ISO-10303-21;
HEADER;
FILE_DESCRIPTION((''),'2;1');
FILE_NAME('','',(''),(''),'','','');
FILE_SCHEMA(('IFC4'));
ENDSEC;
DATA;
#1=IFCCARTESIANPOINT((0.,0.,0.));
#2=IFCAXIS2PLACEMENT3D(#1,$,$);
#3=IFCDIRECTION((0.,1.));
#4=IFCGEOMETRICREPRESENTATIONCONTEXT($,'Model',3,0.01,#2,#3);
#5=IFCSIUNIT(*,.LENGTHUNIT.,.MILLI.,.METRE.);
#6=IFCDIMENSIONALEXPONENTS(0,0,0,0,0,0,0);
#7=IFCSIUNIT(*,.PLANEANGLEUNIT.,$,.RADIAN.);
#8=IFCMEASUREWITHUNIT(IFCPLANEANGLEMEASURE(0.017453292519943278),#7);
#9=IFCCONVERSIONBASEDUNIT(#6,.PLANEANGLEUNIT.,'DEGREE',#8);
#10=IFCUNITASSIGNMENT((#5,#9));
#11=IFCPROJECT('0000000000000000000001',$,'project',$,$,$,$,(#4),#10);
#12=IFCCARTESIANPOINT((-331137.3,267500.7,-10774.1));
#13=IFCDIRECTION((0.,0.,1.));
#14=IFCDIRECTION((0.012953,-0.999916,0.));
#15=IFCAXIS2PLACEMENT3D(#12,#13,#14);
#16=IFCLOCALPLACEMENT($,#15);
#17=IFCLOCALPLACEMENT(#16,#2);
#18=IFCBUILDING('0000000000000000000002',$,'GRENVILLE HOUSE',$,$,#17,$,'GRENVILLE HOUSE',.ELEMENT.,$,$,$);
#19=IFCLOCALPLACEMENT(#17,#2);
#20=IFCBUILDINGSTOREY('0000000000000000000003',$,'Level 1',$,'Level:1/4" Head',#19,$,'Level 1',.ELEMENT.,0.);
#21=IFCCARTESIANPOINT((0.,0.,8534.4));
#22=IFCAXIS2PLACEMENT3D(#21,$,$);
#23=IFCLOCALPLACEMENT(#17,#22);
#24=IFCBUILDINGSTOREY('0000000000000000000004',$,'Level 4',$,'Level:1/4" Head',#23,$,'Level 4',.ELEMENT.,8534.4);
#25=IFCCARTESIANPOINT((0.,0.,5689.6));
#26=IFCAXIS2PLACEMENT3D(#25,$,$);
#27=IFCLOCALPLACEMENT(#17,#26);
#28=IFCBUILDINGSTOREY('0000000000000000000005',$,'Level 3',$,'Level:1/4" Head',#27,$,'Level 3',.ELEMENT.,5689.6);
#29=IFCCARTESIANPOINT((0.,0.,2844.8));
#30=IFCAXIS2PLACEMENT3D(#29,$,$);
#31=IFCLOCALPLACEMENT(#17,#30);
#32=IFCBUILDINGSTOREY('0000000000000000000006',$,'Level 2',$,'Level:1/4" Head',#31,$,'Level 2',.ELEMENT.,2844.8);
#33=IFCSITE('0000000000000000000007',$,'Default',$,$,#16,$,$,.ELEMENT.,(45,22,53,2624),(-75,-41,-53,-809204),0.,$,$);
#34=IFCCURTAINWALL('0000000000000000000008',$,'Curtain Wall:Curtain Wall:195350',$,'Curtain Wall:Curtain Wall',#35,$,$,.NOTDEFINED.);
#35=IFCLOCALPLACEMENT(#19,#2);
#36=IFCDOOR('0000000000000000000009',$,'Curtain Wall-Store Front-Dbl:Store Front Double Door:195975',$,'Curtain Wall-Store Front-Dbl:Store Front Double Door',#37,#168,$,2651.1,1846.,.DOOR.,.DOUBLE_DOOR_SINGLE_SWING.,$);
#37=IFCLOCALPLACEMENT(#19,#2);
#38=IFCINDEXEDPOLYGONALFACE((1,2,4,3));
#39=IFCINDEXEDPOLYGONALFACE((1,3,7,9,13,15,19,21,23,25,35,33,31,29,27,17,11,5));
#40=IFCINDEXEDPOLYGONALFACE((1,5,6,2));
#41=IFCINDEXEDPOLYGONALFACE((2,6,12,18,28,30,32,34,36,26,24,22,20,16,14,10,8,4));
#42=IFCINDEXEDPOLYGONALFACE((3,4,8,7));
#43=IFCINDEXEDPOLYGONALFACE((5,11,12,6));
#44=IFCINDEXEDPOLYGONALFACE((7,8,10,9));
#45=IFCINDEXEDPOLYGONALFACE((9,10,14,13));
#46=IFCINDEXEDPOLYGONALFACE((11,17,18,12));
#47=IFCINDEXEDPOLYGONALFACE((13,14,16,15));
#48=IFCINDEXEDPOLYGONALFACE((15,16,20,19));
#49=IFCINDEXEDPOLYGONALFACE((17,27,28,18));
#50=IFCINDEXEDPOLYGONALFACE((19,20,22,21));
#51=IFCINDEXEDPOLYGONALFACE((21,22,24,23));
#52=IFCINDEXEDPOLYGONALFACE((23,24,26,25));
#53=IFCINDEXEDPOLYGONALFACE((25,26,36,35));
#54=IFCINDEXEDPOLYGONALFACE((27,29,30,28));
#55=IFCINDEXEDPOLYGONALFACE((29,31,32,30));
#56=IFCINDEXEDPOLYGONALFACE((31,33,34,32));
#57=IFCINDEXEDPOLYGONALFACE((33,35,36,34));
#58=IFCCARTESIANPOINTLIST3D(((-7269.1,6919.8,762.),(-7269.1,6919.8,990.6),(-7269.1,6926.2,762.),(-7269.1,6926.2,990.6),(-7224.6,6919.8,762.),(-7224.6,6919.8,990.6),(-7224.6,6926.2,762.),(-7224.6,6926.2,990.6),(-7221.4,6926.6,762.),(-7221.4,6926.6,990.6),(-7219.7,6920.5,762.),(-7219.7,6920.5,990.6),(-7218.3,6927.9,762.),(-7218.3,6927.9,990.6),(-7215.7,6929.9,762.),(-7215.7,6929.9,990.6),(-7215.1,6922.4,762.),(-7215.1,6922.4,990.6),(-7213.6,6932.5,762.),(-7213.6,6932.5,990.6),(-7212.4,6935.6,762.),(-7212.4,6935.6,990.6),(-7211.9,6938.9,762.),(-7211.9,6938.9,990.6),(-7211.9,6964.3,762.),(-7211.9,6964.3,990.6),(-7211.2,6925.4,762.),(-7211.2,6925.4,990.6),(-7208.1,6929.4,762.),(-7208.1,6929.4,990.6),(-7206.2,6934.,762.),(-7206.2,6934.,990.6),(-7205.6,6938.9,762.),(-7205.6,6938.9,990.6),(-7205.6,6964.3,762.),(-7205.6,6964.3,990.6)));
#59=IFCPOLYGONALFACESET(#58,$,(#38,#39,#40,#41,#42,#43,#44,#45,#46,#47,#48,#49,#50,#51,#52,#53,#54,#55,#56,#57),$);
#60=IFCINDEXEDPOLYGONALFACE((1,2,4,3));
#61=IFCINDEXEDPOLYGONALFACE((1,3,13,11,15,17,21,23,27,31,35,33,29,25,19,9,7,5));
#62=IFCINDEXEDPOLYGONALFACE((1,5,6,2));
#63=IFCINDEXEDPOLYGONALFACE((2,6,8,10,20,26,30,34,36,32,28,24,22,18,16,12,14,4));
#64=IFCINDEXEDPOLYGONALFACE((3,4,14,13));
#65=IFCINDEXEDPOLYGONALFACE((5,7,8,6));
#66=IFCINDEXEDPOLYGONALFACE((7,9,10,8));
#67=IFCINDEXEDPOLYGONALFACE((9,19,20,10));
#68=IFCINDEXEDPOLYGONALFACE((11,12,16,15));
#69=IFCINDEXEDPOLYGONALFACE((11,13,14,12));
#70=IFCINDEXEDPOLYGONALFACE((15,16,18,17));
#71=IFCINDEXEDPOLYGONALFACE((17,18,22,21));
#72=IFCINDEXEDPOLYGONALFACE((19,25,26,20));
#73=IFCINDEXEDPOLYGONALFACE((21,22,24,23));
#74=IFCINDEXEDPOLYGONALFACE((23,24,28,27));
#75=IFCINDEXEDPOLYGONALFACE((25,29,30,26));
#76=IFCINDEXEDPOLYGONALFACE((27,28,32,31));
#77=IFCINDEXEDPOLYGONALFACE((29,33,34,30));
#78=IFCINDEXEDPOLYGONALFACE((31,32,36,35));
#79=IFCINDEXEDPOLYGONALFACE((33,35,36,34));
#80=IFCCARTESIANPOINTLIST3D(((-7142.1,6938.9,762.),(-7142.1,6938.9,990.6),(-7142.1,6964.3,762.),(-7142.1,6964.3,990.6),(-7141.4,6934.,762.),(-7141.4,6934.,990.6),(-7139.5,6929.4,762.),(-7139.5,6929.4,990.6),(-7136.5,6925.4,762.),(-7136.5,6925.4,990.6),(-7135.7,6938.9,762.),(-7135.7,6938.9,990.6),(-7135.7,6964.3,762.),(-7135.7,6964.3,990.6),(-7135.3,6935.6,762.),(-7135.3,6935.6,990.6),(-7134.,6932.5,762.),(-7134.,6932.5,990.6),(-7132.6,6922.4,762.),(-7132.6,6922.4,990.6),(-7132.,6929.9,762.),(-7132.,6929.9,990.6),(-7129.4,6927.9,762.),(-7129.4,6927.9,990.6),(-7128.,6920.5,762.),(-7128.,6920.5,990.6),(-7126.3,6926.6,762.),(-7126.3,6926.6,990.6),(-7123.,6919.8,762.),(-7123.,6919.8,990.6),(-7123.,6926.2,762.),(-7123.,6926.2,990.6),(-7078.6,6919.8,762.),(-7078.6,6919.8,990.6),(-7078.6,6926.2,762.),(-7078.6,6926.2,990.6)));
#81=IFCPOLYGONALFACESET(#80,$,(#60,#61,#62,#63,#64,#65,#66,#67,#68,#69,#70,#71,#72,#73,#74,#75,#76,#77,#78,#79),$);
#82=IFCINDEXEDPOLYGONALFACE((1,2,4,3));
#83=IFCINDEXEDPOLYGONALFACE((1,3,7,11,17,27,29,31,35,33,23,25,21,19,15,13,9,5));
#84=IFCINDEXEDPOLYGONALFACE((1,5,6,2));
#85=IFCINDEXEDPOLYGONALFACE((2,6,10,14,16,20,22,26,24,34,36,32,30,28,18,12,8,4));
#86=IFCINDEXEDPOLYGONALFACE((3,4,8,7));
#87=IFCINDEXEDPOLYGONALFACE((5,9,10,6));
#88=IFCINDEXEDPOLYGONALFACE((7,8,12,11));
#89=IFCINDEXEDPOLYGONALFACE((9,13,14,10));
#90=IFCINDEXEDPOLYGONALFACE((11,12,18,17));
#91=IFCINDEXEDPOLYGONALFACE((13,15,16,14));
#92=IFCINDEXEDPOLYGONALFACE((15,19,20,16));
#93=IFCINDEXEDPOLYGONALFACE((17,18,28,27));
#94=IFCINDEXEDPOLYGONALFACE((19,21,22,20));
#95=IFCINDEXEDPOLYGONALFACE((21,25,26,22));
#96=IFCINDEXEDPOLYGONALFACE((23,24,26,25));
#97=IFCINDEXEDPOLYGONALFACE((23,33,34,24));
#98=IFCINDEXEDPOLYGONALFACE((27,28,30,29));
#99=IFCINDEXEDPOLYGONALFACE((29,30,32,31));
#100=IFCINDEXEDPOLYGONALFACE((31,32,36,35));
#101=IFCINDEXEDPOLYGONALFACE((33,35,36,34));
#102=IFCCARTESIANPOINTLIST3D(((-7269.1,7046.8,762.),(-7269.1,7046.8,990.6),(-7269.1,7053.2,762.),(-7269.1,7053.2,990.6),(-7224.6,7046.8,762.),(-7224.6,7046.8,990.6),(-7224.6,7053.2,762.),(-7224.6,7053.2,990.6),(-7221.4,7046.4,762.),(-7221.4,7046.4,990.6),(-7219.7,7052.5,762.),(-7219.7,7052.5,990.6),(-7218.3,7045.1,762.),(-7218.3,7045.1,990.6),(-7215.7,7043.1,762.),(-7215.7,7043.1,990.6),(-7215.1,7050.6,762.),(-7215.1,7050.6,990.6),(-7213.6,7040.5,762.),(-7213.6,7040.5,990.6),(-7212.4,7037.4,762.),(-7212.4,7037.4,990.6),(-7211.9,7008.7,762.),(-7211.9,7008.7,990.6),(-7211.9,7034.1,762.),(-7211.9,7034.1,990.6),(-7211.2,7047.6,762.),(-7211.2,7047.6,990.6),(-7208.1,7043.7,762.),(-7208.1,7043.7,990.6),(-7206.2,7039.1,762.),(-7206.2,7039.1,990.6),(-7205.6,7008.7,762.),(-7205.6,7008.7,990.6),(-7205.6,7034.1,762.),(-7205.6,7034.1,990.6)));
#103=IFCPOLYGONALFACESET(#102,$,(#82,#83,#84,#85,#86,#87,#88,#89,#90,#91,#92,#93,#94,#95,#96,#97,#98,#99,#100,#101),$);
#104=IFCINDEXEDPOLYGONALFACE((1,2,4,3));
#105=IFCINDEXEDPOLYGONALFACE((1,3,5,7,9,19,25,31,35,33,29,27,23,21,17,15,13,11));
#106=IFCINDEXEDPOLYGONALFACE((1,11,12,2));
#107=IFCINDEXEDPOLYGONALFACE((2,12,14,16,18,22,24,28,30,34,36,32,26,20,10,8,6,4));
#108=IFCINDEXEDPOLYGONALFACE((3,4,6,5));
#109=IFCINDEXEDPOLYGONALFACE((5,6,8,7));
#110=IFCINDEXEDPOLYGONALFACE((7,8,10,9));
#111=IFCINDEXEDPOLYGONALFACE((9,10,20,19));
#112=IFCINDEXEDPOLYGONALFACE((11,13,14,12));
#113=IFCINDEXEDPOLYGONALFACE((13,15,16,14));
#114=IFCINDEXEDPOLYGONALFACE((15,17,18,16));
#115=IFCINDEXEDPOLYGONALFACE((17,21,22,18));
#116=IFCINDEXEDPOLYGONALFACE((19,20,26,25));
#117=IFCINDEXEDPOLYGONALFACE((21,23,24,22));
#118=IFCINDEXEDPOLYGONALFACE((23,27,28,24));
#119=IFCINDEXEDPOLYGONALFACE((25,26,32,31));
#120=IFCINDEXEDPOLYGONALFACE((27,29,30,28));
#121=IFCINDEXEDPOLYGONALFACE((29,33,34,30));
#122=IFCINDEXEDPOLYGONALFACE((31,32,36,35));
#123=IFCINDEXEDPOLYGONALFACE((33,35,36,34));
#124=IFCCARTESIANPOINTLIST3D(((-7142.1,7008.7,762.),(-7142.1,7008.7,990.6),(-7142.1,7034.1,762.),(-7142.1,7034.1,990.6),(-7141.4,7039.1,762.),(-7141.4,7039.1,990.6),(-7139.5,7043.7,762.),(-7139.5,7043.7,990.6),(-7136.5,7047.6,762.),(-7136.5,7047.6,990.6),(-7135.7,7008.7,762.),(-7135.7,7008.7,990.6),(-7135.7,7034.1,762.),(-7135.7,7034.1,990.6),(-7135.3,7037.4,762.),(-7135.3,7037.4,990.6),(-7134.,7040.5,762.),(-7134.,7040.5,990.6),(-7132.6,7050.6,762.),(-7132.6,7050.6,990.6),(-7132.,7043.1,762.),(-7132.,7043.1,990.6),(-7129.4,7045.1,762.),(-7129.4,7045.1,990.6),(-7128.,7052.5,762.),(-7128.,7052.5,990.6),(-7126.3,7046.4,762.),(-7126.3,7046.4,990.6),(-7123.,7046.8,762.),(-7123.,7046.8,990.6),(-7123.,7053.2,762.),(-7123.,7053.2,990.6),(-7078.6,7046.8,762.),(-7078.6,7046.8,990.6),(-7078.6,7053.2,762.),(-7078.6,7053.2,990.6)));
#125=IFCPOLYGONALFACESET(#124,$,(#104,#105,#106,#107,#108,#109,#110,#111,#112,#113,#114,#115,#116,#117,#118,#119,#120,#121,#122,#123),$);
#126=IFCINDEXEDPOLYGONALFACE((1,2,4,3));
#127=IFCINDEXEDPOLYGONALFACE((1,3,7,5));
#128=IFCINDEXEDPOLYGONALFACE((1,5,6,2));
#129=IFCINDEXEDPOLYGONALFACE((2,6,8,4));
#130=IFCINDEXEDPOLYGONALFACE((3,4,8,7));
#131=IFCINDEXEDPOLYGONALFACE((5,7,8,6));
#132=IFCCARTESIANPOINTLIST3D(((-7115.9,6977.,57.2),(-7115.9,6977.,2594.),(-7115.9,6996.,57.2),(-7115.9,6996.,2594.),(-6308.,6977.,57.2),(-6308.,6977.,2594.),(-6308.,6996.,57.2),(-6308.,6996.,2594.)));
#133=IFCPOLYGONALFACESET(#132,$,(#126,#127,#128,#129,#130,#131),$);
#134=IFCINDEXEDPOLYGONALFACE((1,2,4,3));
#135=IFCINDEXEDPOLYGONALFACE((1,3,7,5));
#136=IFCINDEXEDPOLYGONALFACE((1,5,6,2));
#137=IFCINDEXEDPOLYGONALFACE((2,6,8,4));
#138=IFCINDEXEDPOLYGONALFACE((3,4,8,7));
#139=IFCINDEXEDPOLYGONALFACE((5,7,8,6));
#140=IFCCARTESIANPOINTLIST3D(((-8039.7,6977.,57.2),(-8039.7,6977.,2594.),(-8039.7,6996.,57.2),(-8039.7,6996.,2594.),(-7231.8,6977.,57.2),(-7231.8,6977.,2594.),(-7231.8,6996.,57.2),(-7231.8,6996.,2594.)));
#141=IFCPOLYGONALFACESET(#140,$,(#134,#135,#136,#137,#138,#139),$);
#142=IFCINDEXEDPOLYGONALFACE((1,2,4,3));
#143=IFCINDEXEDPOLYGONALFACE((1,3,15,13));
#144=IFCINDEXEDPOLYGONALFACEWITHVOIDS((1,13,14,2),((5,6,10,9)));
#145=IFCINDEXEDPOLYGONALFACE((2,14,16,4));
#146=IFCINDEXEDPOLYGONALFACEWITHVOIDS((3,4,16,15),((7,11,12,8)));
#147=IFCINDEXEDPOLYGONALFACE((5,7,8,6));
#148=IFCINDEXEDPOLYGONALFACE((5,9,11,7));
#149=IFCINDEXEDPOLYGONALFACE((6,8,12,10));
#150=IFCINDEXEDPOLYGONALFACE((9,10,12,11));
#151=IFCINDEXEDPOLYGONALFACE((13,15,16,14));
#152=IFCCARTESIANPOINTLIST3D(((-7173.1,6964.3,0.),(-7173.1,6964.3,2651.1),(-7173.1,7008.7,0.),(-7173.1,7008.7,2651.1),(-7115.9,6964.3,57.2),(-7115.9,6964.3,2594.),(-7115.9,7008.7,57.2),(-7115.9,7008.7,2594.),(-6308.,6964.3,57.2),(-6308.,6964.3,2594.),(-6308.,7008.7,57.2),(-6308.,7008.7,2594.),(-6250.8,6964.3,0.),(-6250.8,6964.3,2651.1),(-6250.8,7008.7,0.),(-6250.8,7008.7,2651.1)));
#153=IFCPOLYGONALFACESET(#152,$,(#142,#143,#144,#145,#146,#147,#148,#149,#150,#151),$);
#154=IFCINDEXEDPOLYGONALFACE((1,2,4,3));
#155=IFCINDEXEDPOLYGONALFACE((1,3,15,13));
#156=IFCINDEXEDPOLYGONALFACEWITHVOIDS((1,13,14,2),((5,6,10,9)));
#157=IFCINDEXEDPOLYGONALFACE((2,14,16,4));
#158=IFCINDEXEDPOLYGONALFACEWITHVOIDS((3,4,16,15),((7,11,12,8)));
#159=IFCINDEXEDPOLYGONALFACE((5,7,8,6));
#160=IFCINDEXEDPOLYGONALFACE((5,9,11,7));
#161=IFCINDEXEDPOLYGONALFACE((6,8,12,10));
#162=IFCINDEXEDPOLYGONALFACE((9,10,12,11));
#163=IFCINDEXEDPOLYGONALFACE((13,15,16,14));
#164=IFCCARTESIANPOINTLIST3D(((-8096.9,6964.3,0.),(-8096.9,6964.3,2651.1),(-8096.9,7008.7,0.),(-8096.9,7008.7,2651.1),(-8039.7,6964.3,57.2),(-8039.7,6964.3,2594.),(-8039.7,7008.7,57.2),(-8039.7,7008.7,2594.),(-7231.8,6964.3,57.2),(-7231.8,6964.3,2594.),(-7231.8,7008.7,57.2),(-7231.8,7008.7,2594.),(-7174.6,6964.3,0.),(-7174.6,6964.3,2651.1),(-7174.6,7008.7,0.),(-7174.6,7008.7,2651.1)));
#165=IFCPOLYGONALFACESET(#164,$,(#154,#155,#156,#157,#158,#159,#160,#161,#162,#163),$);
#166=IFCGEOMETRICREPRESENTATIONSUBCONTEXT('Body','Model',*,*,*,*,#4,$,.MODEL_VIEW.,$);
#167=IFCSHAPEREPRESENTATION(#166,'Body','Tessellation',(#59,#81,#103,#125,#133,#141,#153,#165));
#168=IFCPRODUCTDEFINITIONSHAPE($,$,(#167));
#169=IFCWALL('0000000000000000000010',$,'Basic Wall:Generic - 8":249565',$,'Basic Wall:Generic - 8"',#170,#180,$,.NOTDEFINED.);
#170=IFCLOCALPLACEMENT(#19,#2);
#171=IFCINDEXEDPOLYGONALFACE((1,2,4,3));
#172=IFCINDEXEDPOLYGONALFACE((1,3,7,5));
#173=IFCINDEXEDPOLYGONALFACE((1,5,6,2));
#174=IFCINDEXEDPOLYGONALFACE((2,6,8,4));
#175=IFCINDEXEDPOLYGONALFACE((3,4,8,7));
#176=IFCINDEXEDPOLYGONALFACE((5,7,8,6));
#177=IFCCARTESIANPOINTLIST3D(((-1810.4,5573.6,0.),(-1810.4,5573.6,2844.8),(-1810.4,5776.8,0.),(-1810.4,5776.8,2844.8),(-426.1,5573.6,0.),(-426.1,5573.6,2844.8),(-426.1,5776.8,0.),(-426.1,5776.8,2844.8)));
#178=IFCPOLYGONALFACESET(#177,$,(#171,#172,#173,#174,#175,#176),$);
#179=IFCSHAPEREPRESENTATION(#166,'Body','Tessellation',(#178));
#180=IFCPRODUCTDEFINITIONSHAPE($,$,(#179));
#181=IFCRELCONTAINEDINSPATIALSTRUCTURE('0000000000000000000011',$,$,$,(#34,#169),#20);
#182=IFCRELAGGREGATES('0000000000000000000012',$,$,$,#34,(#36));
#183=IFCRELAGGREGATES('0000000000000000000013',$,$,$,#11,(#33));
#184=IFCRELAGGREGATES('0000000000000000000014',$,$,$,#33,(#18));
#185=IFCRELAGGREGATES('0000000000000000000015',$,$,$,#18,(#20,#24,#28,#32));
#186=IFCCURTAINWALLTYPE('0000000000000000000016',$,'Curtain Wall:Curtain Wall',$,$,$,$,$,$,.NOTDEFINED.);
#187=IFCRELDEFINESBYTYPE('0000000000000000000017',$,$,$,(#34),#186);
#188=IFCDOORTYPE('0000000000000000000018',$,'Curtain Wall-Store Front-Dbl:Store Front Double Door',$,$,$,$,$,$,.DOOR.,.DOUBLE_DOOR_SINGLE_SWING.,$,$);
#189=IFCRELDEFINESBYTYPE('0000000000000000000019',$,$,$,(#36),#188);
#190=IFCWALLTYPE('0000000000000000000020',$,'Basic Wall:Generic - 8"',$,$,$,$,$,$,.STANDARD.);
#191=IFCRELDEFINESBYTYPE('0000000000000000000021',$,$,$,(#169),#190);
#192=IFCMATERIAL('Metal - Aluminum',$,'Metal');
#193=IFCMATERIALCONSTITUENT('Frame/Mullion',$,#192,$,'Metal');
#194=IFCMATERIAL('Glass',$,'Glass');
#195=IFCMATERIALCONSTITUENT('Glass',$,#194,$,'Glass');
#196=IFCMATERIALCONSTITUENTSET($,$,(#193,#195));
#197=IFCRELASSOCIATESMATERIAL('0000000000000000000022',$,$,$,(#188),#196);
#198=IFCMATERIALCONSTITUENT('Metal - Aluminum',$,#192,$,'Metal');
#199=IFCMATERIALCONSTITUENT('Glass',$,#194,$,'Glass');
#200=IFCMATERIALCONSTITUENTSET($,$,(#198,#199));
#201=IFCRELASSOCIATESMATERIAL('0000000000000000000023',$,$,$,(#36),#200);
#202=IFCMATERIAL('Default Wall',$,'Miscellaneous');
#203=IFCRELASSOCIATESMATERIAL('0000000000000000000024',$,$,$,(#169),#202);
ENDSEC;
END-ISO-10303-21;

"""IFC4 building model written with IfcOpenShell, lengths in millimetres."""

from ifc_helpers import new_model, entity, si_unit, converted_unit, direction, frame, origin, place, context, subcontext, project, spatial, line, arc, indexed_curve, outline, extrude, source, transform, mapped, material, constituent, constituent_set, type_object, type_shapes, element, aggregate, save


model = new_model("IFC4")

# Units and contexts
model_context = context("Model", 3, precision=0.01, world=origin(), true_north=direction((0.0, 1.0)))
body_context = subcontext(model_context, "Body", "Model", "MODEL_VIEW")
ifc_project = project(units=[si_unit("LENGTHUNIT", "METRE", prefix="MILLI"), converted_unit("PLANEANGLEUNIT", "DEGREE", entity("IfcPlaneAngleMeasure", 0.017453292519943278), si_unit("PLANEANGLEUNIT", "RADIAN"), dimensions=[0, 0, 0, 0, 0, 0, 0])], contexts=[model_context])

# Site, building, storey
site_placement = place(None, frame((-331137.3, 267500.7, -10774.1), z_axis=(0.0, 0.0, 1.0), x_axis=(0.012953, -0.999916, 0.0)))
site = spatial("IfcSite", under=ifc_project, at=site_placement, Name="Default", CompositionType="ELEMENT", RefLatitude=(45, 22, 53, 2624), RefLongitude=(-75, -41, -53, -809204), RefElevation=0.0)
building_placement = place(site_placement, origin())
building = spatial("IfcBuilding", under=site, at=building_placement, Name="GRENVILLE HOUSE", LongName="GRENVILLE HOUSE", CompositionType="ELEMENT")
storey_1_placement = place(building_placement, origin())
storey_1 = spatial("IfcBuildingStorey", under=building, at=storey_1_placement, Name="Level 1", ObjectType="Level:1/4\" Head", LongName="Level 1", CompositionType="ELEMENT", Elevation=0.0)

# Curtain wall
curtain_wall_type = type_object("IfcCurtainWallType", Name="Curtain Wall:Curtain Wall", PredefinedType="NOTDEFINED")
curtain_wall_placement = place(storey_1_placement, origin())
curtain_wall = element("IfcCurtainWall", 1, at=curtain_wall_placement, inside=storey_1, type_object=curtain_wall_type, Name="Curtain Wall:Curtain Wall:195350", ObjectType="Curtain Wall:Curtain Wall", PredefinedType="NOTDEFINED")
ifc_material_1 = material(Name="Glass", Category="Glass")

# Shared definitions
storey_2_placement = place(building_placement, frame((0.0, 0.0, 8534.4)))
storey_2 = spatial("IfcBuildingStorey", under=building, at=storey_2_placement, Name="Level 4", ObjectType="Level:1/4\" Head", LongName="Level 4", CompositionType="ELEMENT", Elevation=8534.4)

# Shared definitions
storey_3_placement = place(building_placement, frame((0.0, 0.0, 5689.6)))
storey_3 = spatial("IfcBuildingStorey", under=building, at=storey_3_placement, Name="Level 3", ObjectType="Level:1/4\" Head", LongName="Level 3", CompositionType="ELEMENT", Elevation=5689.6)

# Shared definitions
storey_4_placement = place(building_placement, frame((0.0, 0.0, 2844.8)))
storey_4 = spatial("IfcBuildingStorey", under=building, at=storey_4_placement, Name="Level 2", ObjectType="Level:1/4\" Head", LongName="Level 2", CompositionType="ELEMENT", Elevation=2844.8)

# Door
ifc_material_2 = material(Name="Metal - Aluminum", Category="Metal")
ifc_constituent_1 = constituent(ifc_material_2, Name="Metal - Aluminum", Category="Metal")
ifc_constituent_2 = constituent(ifc_material_1, Name="Glass", Category="Glass")
ifc_constituent_set_1 = constituent_set(constituents=[ifc_constituent_1, ifc_constituent_2])
ifc_constituent_3 = constituent(ifc_material_2, Name="Frame/Mullion", Category="Metal")
ifc_constituent_4 = constituent(ifc_material_1, Name="Glass", Category="Glass")
ifc_constituent_set_2 = constituent_set(constituents=[ifc_constituent_3, ifc_constituent_4])
door_type_1 = type_object("IfcDoorType", Name="Curtain Wall-Store Front-Dbl:Store Front Double Door", OperationType="DOUBLE_DOOR_SINGLE_SWING", PredefinedType="DOOR", material=ifc_constituent_set_2)
shared_shape_1 = source(origin(), body_context, "Body", "SweptSolid", [
    extrude(outline(indexed_curve([(1.6, -22.2), (27.0, -22.2), (27.0, -15.9), (1.6, -15.9), (-7.4, -12.2), (-11.1, -3.2), (-11.1, 41.3), (-17.5, 41.3), (-17.5, -3.2), (-11.9, -16.6)], segments=[line(1, 2, 3, 4), arc(4, 5, 6), line(6, 7, 8, 9), arc(9, 10, 1)], self_intersect=False)), frame((-54.0, -14.3, 762.0), z_axis=(0.0, 0.0, 1.0), x_axis=(0.0, 1.0, 0.0)), (0.0, 0.0, 1.0), 228.6),
    extrude(outline(indexed_curve([(22.2, -1.6), (16.6, 11.9), (3.2, 17.5), (-41.3, 17.5), (-41.3, 11.1), (3.2, 11.1), (12.2, 7.4), (15.9, -1.6), (15.9, -27.0), (22.2, -27.0)], segments=[arc(1, 2, 3), line(3, 4, 5, 6), arc(6, 7, 8), line(8, 9, 10, 1)], self_intersect=False)), frame((54.0, -14.3, 762.0), z_axis=(0.0, 0.0, 1.0), x_axis=(-1.0, 0.0, 0.0)), (0.0, 0.0, 1.0), 228.6),
    extrude(outline(indexed_curve([(-22.2, 1.6), (-16.6, -11.9), (-3.2, -17.5), (41.3, -17.5), (41.3, -11.1), (-3.2, -11.1), (-12.2, -7.4), (-15.9, 1.6), (-15.9, 27.0), (-22.2, 27.0)], segments=[arc(1, 2, 3), line(3, 4, 5, 6), arc(6, 7, 8), line(8, 9, 10, 1)], self_intersect=False)), frame((-54.0, 84.1, 762.0), z_axis=(0.0, 0.0, 1.0), x_axis=(-1.0, 0.0, 0.0)), (0.0, 0.0, 1.0), 228.6),
    extrude(outline(indexed_curve([(1.6, -22.2), (27.0, -22.2), (27.0, -15.9), (1.6, -15.9), (-7.4, -12.2), (-11.1, -3.2), (-11.1, 41.3), (-17.5, 41.3), (-17.5, -3.2), (-11.9, -16.6)], segments=[line(1, 2, 3, 4), arc(4, 5, 6), line(6, 7, 8, 9), arc(9, 10, 1)], self_intersect=False)), frame((54.0, 84.1, 762.0), z_axis=(0.0, 0.0, 1.0), x_axis=(0.0, -1.0, 0.0)), (0.0, 0.0, 1.0), 228.6),
    extrude(outline(indexed_curve([(-404.0, -9.5), (404.0, -9.5), (404.0, 9.5), (-404.0, 9.5), (-404.0, -9.5)], self_intersect=False)), frame((461.9, 34.9, 57.2)), (0.0, 0.0, 1.0), 2536.8),
    extrude(outline(indexed_curve([(-404.0, -9.5), (404.0, -9.5), (404.0, 9.5), (-404.0, 9.5), (-404.0, -9.5)], self_intersect=False)), frame((-461.9, 34.9, 57.2)), (0.0, 0.0, 1.0), 2536.8),
    extrude(outline(indexed_curve([(-1325.6, -461.1), (1325.6, -461.1), (1325.6, 461.1), (-1325.6, 461.1), (-1325.6, -461.1)], self_intersect=False), holes=[indexed_curve([(-1268.4, 404.0), (1268.4, 404.0), (1268.4, -404.0), (-1268.4, -404.0), (-1268.4, 404.0)], self_intersect=False)]), frame((461.9, 57.2, 1325.6), z_axis=(0.0, -1.0, 0.0), x_axis=(0.0, 0.0, -1.0)), (0.0, 0.0, 1.0), 44.4),
    extrude(outline(indexed_curve([(-461.1, -1325.6), (461.1, -1325.6), (461.1, 1325.6), (-461.1, 1325.6), (-461.1, -1325.6)], self_intersect=False), holes=[indexed_curve([(-404.0, -1268.4), (-404.0, 1268.4), (404.0, 1268.4), (404.0, -1268.4), (-404.0, -1268.4)], self_intersect=False)]), frame((-461.9, 57.2, 1325.6), z_axis=(0.0, -1.0, 0.0), x_axis=(-1.0, 0.0, 0.0)), (0.0, 0.0, 1.0), 44.4),
])
type_shapes(door_type_1, [shared_shape_1])
door_1_placement = place(curtain_wall_placement, frame((-7173.8, 6951.6, 0.0)))
door_1 = element("IfcDoor", 2, at=door_1_placement, type_object=door_type_1, material=ifc_constituent_set_1, Name="Curtain Wall-Store Front-Dbl:Store Front Double Door:195975", ObjectType="Curtain Wall-Store Front-Dbl:Store Front Double Door", OperationType="DOUBLE_DOOR_SINGLE_SWING", OverallHeight=2651.1, OverallWidth=1846.0, PredefinedType="DOOR", context=body_context, shape_type="MappedRepresentation", body=[
    mapped(shared_shape_1, transform((0.0, 0.0, 0.0), scale=1.0)),
])
aggregate(curtain_wall, [door_1])

# Wall
ifc_material_3 = material(Name="Default Wall", Category="Miscellaneous")
wall_type_1 = type_object("IfcWallType", Name="Basic Wall:Generic - 8\"", PredefinedType="STANDARD")
wall_1_placement = place(storey_1_placement, frame((-426.1, 5675.2, 0.0), z_axis=(0.0, 0.0, 1.0), x_axis=(-1.0, 0.0, 0.0)))
element("IfcWall", 3, at=wall_1_placement, inside=storey_1, type_object=wall_type_1, material=ifc_material_3, Name="Basic Wall:Generic - 8\":249565", ObjectType="Basic Wall:Generic - 8\"", PredefinedType="NOTDEFINED", context=body_context, shape_type="SweptSolid", body=[
    extrude(outline(indexed_curve([(1384.3, 101.6), (0.0, 101.6), (0.0, -101.6), (1384.3, -101.6), (1384.3, 101.6)], self_intersect=False)), origin(), (0.0, 0.0, 1.0), 2844.8),
])

save(model, "model.ifc")
